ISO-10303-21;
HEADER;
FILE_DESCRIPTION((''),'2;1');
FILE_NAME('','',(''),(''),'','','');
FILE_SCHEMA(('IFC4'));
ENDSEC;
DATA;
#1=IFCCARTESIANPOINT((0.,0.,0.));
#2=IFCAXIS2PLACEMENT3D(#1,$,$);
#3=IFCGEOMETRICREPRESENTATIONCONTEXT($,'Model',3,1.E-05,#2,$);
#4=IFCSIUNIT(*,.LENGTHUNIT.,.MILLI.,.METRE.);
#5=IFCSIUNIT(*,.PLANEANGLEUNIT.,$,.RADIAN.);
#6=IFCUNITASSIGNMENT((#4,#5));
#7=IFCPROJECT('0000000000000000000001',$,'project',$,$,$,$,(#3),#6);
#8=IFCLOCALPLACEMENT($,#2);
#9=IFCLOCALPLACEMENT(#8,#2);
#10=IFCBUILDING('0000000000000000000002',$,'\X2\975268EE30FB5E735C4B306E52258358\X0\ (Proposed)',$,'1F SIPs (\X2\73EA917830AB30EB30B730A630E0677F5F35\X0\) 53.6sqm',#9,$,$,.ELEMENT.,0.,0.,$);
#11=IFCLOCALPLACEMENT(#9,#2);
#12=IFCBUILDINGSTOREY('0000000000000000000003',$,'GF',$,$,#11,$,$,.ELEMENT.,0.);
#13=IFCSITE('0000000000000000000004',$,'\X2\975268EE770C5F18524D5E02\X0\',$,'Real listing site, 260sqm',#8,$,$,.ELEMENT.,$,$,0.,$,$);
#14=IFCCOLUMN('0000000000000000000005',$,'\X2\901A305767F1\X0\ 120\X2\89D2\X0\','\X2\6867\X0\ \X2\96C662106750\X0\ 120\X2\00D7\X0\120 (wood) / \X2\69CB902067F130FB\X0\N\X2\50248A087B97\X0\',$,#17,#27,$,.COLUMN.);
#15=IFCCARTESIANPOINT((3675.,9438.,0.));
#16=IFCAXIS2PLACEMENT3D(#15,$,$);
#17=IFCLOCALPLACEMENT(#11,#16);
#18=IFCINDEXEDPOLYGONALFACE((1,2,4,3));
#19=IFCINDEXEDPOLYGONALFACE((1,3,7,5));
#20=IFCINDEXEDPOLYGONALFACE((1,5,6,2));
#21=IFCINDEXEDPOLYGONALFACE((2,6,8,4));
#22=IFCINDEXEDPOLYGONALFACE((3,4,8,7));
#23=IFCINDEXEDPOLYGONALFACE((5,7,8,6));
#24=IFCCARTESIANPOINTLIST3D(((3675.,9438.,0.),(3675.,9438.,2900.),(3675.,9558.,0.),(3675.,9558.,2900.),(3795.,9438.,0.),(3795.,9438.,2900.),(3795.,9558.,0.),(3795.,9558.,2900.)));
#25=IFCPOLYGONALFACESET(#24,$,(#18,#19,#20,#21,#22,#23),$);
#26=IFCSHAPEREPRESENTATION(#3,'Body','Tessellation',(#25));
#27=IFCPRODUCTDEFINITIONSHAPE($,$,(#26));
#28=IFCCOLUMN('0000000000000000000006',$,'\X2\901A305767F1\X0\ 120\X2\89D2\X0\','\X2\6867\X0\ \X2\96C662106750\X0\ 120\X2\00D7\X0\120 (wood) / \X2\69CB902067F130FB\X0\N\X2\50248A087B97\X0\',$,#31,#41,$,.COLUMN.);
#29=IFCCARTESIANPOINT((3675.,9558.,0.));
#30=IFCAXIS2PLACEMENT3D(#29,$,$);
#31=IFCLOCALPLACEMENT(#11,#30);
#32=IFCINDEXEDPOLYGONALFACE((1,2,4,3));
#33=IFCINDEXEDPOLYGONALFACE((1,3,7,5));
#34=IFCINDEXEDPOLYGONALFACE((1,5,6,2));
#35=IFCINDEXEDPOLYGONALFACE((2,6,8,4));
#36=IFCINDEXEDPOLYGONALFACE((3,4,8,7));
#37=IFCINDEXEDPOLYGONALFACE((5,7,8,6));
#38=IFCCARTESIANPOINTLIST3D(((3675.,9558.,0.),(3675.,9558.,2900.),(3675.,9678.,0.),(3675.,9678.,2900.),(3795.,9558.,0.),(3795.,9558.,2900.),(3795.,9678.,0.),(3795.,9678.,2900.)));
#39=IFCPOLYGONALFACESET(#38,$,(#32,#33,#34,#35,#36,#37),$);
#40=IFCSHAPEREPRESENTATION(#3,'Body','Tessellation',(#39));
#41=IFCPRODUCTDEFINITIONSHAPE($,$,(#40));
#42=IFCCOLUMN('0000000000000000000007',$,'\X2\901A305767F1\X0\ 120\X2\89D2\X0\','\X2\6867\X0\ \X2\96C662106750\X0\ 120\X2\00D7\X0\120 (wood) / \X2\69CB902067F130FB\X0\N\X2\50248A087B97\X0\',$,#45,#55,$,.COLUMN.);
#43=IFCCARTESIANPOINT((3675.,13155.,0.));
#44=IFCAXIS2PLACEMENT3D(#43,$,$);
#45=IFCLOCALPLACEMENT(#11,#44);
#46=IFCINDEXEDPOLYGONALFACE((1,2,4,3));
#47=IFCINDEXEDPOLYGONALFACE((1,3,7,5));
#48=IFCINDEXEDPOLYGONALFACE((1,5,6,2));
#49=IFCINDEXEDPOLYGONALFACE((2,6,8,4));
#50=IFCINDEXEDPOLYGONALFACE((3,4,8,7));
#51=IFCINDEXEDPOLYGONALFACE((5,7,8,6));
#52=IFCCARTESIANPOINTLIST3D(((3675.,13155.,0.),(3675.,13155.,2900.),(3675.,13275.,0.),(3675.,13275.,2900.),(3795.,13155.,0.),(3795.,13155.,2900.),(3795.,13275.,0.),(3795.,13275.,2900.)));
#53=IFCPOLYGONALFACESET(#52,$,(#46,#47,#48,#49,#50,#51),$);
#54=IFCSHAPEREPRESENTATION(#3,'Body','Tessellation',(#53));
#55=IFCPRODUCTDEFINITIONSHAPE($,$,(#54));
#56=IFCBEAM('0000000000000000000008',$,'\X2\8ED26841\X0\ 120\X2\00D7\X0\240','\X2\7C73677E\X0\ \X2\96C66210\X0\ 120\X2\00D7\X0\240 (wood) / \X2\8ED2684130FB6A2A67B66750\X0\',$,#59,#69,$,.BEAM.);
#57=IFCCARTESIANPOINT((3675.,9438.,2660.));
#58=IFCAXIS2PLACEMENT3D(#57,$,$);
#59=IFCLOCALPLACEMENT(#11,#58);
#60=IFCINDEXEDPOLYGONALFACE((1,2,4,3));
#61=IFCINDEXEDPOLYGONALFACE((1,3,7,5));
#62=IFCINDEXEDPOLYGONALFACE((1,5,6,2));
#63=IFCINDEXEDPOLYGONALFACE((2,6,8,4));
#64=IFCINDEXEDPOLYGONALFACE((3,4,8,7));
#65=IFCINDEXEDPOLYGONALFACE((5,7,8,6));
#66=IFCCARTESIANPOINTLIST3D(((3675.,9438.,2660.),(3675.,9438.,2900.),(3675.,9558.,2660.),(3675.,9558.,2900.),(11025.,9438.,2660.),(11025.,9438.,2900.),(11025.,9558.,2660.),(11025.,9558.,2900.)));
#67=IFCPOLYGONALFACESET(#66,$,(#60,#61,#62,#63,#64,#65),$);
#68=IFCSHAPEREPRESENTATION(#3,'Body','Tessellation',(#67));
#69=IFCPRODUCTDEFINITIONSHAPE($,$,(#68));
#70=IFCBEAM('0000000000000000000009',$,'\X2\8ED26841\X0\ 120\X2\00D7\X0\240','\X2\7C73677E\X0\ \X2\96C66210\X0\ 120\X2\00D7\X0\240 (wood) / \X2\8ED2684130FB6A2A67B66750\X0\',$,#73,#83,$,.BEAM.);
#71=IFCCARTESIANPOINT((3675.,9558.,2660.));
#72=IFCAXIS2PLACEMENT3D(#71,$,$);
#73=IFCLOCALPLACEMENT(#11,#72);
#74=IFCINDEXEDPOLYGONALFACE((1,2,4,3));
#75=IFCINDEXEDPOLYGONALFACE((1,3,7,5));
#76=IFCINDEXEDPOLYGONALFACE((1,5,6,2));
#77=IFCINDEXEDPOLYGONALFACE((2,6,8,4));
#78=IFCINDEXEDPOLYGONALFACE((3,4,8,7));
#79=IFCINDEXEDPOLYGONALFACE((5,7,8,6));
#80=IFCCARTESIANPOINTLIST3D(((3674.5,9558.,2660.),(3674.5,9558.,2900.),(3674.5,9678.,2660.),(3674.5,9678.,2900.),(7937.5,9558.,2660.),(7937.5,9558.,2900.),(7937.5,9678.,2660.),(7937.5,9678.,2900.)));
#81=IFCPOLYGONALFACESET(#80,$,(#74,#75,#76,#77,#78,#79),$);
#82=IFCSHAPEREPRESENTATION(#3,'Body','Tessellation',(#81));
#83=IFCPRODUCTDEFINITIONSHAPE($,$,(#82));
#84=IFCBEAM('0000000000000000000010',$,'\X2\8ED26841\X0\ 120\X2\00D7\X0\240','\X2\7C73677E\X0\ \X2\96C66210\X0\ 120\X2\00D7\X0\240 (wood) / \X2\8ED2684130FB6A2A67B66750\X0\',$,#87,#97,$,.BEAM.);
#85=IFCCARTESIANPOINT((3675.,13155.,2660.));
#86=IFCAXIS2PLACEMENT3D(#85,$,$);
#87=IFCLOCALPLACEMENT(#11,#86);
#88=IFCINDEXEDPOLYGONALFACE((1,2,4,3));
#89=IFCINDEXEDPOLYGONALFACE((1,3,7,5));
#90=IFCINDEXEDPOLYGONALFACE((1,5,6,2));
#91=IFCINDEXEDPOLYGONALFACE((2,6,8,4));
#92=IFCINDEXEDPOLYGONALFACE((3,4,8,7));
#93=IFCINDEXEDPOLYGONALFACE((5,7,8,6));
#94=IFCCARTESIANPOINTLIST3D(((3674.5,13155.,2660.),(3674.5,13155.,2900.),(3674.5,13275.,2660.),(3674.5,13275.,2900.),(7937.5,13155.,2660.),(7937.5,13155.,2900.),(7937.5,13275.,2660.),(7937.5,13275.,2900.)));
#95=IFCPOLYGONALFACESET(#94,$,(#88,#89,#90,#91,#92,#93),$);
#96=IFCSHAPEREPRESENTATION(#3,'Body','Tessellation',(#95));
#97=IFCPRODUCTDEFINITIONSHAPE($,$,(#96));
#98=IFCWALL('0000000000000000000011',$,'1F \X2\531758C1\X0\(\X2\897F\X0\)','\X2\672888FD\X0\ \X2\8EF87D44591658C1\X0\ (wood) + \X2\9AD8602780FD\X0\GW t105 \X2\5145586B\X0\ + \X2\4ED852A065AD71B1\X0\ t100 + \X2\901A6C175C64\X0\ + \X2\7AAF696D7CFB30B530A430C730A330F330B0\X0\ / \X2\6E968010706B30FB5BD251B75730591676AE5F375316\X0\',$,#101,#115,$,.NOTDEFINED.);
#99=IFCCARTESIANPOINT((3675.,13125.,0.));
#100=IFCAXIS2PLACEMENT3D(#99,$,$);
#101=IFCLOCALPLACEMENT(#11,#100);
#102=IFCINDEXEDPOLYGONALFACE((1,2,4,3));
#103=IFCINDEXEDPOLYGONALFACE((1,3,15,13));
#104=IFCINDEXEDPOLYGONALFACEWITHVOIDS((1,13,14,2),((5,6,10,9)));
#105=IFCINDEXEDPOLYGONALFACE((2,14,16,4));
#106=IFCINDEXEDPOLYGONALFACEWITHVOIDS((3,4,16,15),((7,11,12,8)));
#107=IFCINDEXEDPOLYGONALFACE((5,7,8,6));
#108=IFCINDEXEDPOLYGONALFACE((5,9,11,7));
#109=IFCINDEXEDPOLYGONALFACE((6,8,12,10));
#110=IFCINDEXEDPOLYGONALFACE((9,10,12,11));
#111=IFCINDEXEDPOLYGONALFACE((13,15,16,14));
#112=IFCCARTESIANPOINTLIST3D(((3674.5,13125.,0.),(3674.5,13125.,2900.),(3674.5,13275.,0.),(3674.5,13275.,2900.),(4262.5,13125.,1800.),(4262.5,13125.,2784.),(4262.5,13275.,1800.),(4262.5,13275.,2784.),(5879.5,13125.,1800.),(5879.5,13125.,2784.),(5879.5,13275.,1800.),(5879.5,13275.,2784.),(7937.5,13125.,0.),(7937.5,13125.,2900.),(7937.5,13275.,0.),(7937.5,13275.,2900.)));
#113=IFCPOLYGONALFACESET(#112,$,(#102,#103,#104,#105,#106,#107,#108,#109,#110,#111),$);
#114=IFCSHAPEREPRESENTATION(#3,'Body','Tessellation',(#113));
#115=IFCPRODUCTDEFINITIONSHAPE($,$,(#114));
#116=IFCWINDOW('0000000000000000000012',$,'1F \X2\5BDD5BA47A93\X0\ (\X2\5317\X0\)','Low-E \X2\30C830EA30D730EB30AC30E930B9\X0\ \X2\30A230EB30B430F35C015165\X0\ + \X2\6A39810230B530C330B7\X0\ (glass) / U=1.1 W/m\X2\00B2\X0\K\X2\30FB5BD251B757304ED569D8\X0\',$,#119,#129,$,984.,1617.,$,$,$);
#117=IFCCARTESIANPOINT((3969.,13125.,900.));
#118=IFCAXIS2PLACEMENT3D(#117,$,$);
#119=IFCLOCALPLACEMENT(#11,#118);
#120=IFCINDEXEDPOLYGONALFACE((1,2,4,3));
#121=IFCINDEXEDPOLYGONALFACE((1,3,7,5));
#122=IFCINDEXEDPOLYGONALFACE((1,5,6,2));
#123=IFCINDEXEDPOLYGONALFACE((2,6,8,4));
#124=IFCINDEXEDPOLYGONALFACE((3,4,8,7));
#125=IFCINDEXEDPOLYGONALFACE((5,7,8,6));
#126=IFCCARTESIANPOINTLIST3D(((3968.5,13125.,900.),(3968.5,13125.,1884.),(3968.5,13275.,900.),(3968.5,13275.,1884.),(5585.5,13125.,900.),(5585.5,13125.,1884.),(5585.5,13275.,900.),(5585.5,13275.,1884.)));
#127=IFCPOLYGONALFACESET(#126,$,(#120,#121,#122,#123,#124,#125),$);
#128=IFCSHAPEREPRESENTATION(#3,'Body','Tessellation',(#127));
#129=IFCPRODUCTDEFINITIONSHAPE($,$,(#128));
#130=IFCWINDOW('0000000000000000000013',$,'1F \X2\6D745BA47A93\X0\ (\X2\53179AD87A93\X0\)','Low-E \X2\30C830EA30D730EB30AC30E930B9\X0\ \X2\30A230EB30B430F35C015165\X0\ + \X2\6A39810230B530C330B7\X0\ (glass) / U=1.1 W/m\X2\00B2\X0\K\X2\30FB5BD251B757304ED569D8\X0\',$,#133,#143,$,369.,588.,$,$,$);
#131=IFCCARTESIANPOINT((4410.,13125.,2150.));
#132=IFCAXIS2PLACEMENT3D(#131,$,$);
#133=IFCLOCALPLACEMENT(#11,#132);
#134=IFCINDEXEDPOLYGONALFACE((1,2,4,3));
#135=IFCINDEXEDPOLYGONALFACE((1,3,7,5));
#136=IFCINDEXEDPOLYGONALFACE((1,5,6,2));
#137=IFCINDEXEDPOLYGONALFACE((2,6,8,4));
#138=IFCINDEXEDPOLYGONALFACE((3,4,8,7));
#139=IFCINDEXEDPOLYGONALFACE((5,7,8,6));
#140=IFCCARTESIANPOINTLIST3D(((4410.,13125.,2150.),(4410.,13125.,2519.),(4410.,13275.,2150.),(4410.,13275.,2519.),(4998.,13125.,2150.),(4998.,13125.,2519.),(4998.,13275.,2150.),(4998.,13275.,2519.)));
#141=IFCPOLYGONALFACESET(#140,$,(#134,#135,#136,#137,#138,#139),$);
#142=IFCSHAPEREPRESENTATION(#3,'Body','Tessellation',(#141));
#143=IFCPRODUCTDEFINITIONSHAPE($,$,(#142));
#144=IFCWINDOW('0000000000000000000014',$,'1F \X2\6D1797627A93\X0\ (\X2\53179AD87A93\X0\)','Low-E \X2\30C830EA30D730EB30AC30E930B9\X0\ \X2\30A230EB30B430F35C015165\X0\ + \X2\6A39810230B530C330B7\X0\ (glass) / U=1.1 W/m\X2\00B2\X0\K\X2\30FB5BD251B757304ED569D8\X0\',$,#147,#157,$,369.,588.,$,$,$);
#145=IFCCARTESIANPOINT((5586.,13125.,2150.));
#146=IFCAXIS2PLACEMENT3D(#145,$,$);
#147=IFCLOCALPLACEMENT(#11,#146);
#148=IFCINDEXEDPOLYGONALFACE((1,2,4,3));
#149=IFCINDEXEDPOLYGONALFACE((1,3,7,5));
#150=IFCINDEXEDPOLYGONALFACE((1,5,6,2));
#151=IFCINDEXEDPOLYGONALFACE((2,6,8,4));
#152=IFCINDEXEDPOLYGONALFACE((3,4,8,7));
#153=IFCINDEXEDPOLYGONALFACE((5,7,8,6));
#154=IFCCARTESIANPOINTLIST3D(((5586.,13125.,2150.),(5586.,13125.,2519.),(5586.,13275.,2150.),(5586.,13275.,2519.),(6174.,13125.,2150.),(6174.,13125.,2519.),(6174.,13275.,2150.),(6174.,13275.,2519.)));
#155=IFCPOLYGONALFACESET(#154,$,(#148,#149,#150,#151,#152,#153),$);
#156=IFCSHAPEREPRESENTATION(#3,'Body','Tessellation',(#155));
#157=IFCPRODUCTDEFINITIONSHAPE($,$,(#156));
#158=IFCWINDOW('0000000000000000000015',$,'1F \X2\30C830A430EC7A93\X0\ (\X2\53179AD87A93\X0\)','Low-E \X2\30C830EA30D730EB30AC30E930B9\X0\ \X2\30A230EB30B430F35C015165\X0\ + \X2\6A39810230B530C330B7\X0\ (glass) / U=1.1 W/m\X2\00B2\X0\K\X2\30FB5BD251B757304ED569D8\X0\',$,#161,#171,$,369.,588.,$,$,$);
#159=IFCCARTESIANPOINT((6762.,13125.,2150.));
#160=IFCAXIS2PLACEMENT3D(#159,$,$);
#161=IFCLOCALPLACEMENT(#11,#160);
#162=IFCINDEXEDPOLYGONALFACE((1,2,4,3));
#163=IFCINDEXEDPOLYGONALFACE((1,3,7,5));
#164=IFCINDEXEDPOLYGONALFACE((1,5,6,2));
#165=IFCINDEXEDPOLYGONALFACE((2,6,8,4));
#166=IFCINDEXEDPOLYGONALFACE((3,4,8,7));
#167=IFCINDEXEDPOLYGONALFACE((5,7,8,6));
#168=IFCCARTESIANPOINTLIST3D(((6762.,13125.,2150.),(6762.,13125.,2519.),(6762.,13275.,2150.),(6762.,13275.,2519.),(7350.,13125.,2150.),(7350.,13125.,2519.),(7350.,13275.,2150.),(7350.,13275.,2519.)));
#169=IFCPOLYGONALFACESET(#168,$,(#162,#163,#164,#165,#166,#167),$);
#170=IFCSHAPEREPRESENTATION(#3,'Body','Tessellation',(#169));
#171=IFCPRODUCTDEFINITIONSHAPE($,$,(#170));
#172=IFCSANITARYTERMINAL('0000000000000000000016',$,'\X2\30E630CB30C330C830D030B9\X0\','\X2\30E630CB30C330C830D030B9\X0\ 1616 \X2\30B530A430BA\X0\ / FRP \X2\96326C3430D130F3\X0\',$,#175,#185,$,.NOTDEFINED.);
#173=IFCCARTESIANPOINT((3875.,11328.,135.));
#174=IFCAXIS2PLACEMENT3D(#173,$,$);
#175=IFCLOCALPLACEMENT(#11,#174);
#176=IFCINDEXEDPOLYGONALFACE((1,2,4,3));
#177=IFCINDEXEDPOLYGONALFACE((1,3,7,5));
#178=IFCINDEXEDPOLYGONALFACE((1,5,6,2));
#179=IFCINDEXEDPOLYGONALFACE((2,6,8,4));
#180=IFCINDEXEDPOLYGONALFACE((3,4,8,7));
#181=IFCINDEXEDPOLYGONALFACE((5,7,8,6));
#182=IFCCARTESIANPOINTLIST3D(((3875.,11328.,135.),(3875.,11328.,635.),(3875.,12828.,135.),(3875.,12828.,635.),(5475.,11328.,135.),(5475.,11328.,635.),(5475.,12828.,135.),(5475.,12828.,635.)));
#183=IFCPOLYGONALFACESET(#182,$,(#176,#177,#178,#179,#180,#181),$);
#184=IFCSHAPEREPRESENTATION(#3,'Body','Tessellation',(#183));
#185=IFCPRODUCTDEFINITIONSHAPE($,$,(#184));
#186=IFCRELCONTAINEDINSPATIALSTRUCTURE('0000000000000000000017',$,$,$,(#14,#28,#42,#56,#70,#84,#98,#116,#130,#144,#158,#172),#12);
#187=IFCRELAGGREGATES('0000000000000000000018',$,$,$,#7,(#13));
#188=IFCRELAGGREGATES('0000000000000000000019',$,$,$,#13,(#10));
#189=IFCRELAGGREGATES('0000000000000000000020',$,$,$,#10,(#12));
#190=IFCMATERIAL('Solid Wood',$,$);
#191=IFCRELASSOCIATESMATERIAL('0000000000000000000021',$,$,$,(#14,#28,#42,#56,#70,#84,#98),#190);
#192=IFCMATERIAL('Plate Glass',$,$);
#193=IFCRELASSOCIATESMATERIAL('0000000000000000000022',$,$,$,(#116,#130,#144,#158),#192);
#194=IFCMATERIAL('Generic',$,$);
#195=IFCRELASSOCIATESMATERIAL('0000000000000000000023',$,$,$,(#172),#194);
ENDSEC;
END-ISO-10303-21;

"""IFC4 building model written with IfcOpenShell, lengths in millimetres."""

from ifc_helpers import new_model, si_unit, frame, frame_2d, origin, place, context, project, spatial, rectangle, extrude, material, element, fill, save


model = new_model("IFC4")

# Units and contexts
model_context = context("Model", 3, precision=1e-05, world=origin())
ifc_project = project(units=[si_unit("LENGTHUNIT", "METRE", prefix="MILLI"), si_unit("PLANEANGLEUNIT", "RADIAN")], contexts=[model_context])

# Site, building, storey
site_placement = place(None, origin())
site = spatial("IfcSite", under=ifc_project, at=site_placement, Name="青森県弘前市", ObjectType="Real listing site, 260sqm", CompositionType="ELEMENT", RefElevation=0.0)
building_placement = place(site_placement, origin())
building = spatial("IfcBuilding", under=site, at=building_placement, Name="青森・平屋の別荘 (Proposed)", ObjectType="1F SIPs (珪酸カルシウム板張) 53.6sqm", CompositionType="ELEMENT", ElevationOfRefHeight=0.0, ElevationOfTerrain=0.0)
storey_placement = place(building_placement, origin())
storey = spatial("IfcBuildingStorey", under=building, at=storey_placement, Name="GF", CompositionType="ELEMENT", Elevation=0.0)

# Columns
ifc_material_1 = material(Name="Solid Wood")
column_1_placement = place(storey_placement, frame((3675.0, 9438.0, 0.0)))
element("IfcColumn", 1, at=column_1_placement, inside=storey, material=ifc_material_1, Name="通し柱 120角", Description="桧 集成材 120×120 (wood) / 構造柱・N値計算", PredefinedType="COLUMN", context=model_context, shape_type="SweptSolid", body=[
    extrude(rectangle(XDim=120.0, YDim=120.0, at=frame_2d((60.0, 60.0))), frame((3675.0, 9438.0, 0.0)), (0.0, 0.0, 1.0), 2900.0),
])
column_2_placement = place(storey_placement, frame((3675.0, 9558.0, 0.0)))
element("IfcColumn", 2, at=column_2_placement, inside=storey, material=ifc_material_1, Name="通し柱 120角", Description="桧 集成材 120×120 (wood) / 構造柱・N値計算", PredefinedType="COLUMN", context=model_context, shape_type="SweptSolid", body=[
    extrude(rectangle(XDim=120.0, YDim=120.0, at=frame_2d((60.0, 60.0))), frame((3675.0, 9558.0, 0.0)), (0.0, 0.0, 1.0), 2900.0),
])
column_3_placement = place(storey_placement, frame((3675.0, 13155.0, 0.0)))
element("IfcColumn", 3, at=column_3_placement, inside=storey, material=ifc_material_1, Name="通し柱 120角", Description="桧 集成材 120×120 (wood) / 構造柱・N値計算", PredefinedType="COLUMN", context=model_context, shape_type="SweptSolid", body=[
    extrude(rectangle(XDim=120.0, YDim=120.0, at=frame_2d((60.0, 60.0))), frame((3675.0, 13155.0, 0.0)), (0.0, 0.0, 1.0), 2900.0),
])

# Beams
beam_1_placement = place(storey_placement, frame((3675.0, 9438.0, 2660.0)))
element("IfcBeam", 4, at=beam_1_placement, inside=storey, material=ifc_material_1, Name="軒桁 120×240", Description="米松 集成 120×240 (wood) / 軒桁・横架材", PredefinedType="BEAM", context=model_context, shape_type="SweptSolid", body=[
    extrude(rectangle(XDim=7350.0, YDim=120.0, at=frame_2d((3675.0, 60.0))), frame((3675.0, 9438.0, 2660.0)), (0.0, 0.0, 1.0), 240.0),
])
beam_2_placement = place(storey_placement, frame((3675.0, 9558.0, 2660.0)))
element("IfcBeam", 5, at=beam_2_placement, inside=storey, material=ifc_material_1, Name="軒桁 120×240", Description="米松 集成 120×240 (wood) / 軒桁・横架材", PredefinedType="BEAM", context=model_context, shape_type="SweptSolid", body=[
    extrude(rectangle(XDim=4263.0, YDim=120.0, at=frame_2d((2131.0, 60.0))), frame((3675.0, 9558.0, 2660.0)), (0.0, 0.0, 1.0), 240.0),
])
beam_3_placement = place(storey_placement, frame((3675.0, 13155.0, 2660.0)))
element("IfcBeam", 6, at=beam_3_placement, inside=storey, material=ifc_material_1, Name="軒桁 120×240", Description="米松 集成 120×240 (wood) / 軒桁・横架材", PredefinedType="BEAM", context=model_context, shape_type="SweptSolid", body=[
    extrude(rectangle(XDim=4263.0, YDim=120.0, at=frame_2d((2131.0, 60.0))), frame((3675.0, 13155.0, 2660.0)), (0.0, 0.0, 1.0), 240.0),
])

# Wall, openings, windows
wall_1_placement = place(storey_placement, frame((3675.0, 13125.0, 0.0)))
wall_1 = element("IfcWall", 7, at=wall_1_placement, inside=storey, material=ifc_material_1, Name="1F 北壁(西)", Description="木製 軸組外壁 (wood) + 高性能GW t105 充填 + 付加断熱 t100 + 通気層 + 窯業系サイディング / 準耐火・寒冷地外皮強化", PredefinedType="NOTDEFINED", context=model_context, shape_type="SweptSolid", body=[
    extrude(rectangle(XDim=4263.0, YDim=150.0, at=frame_2d((2131.0, 75.0))), frame((3675.0, 13125.0, 0.0)), (0.0, 0.0, 1.0), 2900.0),
])
opening_1_placement = place(storey_placement, frame((3969.0, 13125.0, 900.0)))
opening_1 = element("IfcOpeningElement", 8, at=opening_1_placement, cuts=wall_1, PredefinedType="NOTDEFINED", context=model_context, shape_type="SweptSolid", body=[
    extrude(rectangle(XDim=1617.0, YDim=150.0, at=frame_2d((808.0, 75.0))), frame((3969.0, 13125.0, 900.0)), (0.0, 0.0, 1.0), 984.0),
])
opening_2_placement = place(storey_placement, frame((4410.0, 13125.0, 2150.0)))
opening_2 = element("IfcOpeningElement", 9, at=opening_2_placement, cuts=wall_1, PredefinedType="NOTDEFINED", context=model_context, shape_type="SweptSolid", body=[
    extrude(rectangle(XDim=588.0, YDim=150.0, at=frame_2d((294.0, 75.0))), frame((4410.0, 13125.0, 2150.0)), (0.0, 0.0, 1.0), 369.0),
])
opening_3_placement = place(storey_placement, frame((5586.0, 13125.0, 2150.0)))
opening_3 = element("IfcOpeningElement", 10, at=opening_3_placement, cuts=wall_1, PredefinedType="NOTDEFINED", context=model_context, shape_type="SweptSolid", body=[
    extrude(rectangle(XDim=588.0, YDim=150.0, at=frame_2d((294.0, 75.0))), frame((5586.0, 13125.0, 2150.0)), (0.0, 0.0, 1.0), 369.0),
])
opening_4_placement = place(storey_placement, frame((6762.0, 13125.0, 2150.0)))
opening_4 = element("IfcOpeningElement", 11, at=opening_4_placement, cuts=wall_1, PredefinedType="NOTDEFINED", context=model_context, shape_type="SweptSolid", body=[
    extrude(rectangle(XDim=588.0, YDim=150.0, at=frame_2d((294.0, 75.0))), frame((6762.0, 13125.0, 2150.0)), (0.0, 0.0, 1.0), 369.0),
])
ifc_material_2 = material(Name="Plate Glass")
window_1_placement = place(storey_placement, frame((3969.0, 13125.0, 900.0)))
window_1 = element("IfcWindow", 12, at=window_1_placement, inside=storey, material=ifc_material_2, Name="1F 寝室窓 (北)", Description="Low-E トリプルガラス アルゴン封入 + 樹脂サッシ (glass) / U=1.1 W/m²K・寒冷地仕様", OverallHeight=984.0, OverallWidth=1617.0, context=model_context, shape_type="SweptSolid", body=[
    extrude(rectangle(XDim=1617.0, YDim=150.0, at=frame_2d((808.0, 75.0))), frame((3969.0, 13125.0, 900.0)), (0.0, 0.0, 1.0), 984.0),
])
fill(opening_1, window_1)
window_2_placement = place(storey_placement, frame((4410.0, 13125.0, 2150.0)))
window_2 = element("IfcWindow", 13, at=window_2_placement, inside=storey, material=ifc_material_2, Name="1F 浴室窓 (北高窓)", Description="Low-E トリプルガラス アルゴン封入 + 樹脂サッシ (glass) / U=1.1 W/m²K・寒冷地仕様", OverallHeight=369.0, OverallWidth=588.0, context=model_context, shape_type="SweptSolid", body=[
    extrude(rectangle(XDim=588.0, YDim=150.0, at=frame_2d((294.0, 75.0))), frame((4410.0, 13125.0, 2150.0)), (0.0, 0.0, 1.0), 369.0),
])
fill(opening_2, window_2)
window_3_placement = place(storey_placement, frame((5586.0, 13125.0, 2150.0)))
window_3 = element("IfcWindow", 14, at=window_3_placement, inside=storey, material=ifc_material_2, Name="1F 洗面窓 (北高窓)", Description="Low-E トリプルガラス アルゴン封入 + 樹脂サッシ (glass) / U=1.1 W/m²K・寒冷地仕様", OverallHeight=369.0, OverallWidth=588.0, context=model_context, shape_type="SweptSolid", body=[
    extrude(rectangle(XDim=588.0, YDim=150.0, at=frame_2d((294.0, 75.0))), frame((5586.0, 13125.0, 2150.0)), (0.0, 0.0, 1.0), 369.0),
])
fill(opening_3, window_3)
window_4_placement = place(storey_placement, frame((6762.0, 13125.0, 2150.0)))
window_4 = element("IfcWindow", 15, at=window_4_placement, inside=storey, material=ifc_material_2, Name="1F トイレ窓 (北高窓)", Description="Low-E トリプルガラス アルゴン封入 + 樹脂サッシ (glass) / U=1.1 W/m²K・寒冷地仕様", OverallHeight=369.0, OverallWidth=588.0, context=model_context, shape_type="SweptSolid", body=[
    extrude(rectangle(XDim=588.0, YDim=150.0, at=frame_2d((294.0, 75.0))), frame((6762.0, 13125.0, 2150.0)), (0.0, 0.0, 1.0), 369.0),
])
fill(opening_4, window_4)

# Shared definitions
ifc_material_3 = material(Name="Generic")

# Sanitary terminal
sanitary_terminal_placement = place(storey_placement, frame((3875.0, 11328.0, 135.0)))
element("IfcSanitaryTerminal", 16, at=sanitary_terminal_placement, inside=storey, material=ifc_material_3, Name="ユニットバス", Description="ユニットバス 1616 サイズ / FRP 防水パン", PredefinedType="NOTDEFINED", context=model_context, shape_type="SweptSolid", body=[
    extrude(rectangle(XDim=1600.0, YDim=1500.0, at=frame_2d((800.0, 750.0))), frame((3875.0, 11328.0, 135.0)), (0.0, 0.0, 1.0), 500.0),
])

save(model, "model.ifc")
